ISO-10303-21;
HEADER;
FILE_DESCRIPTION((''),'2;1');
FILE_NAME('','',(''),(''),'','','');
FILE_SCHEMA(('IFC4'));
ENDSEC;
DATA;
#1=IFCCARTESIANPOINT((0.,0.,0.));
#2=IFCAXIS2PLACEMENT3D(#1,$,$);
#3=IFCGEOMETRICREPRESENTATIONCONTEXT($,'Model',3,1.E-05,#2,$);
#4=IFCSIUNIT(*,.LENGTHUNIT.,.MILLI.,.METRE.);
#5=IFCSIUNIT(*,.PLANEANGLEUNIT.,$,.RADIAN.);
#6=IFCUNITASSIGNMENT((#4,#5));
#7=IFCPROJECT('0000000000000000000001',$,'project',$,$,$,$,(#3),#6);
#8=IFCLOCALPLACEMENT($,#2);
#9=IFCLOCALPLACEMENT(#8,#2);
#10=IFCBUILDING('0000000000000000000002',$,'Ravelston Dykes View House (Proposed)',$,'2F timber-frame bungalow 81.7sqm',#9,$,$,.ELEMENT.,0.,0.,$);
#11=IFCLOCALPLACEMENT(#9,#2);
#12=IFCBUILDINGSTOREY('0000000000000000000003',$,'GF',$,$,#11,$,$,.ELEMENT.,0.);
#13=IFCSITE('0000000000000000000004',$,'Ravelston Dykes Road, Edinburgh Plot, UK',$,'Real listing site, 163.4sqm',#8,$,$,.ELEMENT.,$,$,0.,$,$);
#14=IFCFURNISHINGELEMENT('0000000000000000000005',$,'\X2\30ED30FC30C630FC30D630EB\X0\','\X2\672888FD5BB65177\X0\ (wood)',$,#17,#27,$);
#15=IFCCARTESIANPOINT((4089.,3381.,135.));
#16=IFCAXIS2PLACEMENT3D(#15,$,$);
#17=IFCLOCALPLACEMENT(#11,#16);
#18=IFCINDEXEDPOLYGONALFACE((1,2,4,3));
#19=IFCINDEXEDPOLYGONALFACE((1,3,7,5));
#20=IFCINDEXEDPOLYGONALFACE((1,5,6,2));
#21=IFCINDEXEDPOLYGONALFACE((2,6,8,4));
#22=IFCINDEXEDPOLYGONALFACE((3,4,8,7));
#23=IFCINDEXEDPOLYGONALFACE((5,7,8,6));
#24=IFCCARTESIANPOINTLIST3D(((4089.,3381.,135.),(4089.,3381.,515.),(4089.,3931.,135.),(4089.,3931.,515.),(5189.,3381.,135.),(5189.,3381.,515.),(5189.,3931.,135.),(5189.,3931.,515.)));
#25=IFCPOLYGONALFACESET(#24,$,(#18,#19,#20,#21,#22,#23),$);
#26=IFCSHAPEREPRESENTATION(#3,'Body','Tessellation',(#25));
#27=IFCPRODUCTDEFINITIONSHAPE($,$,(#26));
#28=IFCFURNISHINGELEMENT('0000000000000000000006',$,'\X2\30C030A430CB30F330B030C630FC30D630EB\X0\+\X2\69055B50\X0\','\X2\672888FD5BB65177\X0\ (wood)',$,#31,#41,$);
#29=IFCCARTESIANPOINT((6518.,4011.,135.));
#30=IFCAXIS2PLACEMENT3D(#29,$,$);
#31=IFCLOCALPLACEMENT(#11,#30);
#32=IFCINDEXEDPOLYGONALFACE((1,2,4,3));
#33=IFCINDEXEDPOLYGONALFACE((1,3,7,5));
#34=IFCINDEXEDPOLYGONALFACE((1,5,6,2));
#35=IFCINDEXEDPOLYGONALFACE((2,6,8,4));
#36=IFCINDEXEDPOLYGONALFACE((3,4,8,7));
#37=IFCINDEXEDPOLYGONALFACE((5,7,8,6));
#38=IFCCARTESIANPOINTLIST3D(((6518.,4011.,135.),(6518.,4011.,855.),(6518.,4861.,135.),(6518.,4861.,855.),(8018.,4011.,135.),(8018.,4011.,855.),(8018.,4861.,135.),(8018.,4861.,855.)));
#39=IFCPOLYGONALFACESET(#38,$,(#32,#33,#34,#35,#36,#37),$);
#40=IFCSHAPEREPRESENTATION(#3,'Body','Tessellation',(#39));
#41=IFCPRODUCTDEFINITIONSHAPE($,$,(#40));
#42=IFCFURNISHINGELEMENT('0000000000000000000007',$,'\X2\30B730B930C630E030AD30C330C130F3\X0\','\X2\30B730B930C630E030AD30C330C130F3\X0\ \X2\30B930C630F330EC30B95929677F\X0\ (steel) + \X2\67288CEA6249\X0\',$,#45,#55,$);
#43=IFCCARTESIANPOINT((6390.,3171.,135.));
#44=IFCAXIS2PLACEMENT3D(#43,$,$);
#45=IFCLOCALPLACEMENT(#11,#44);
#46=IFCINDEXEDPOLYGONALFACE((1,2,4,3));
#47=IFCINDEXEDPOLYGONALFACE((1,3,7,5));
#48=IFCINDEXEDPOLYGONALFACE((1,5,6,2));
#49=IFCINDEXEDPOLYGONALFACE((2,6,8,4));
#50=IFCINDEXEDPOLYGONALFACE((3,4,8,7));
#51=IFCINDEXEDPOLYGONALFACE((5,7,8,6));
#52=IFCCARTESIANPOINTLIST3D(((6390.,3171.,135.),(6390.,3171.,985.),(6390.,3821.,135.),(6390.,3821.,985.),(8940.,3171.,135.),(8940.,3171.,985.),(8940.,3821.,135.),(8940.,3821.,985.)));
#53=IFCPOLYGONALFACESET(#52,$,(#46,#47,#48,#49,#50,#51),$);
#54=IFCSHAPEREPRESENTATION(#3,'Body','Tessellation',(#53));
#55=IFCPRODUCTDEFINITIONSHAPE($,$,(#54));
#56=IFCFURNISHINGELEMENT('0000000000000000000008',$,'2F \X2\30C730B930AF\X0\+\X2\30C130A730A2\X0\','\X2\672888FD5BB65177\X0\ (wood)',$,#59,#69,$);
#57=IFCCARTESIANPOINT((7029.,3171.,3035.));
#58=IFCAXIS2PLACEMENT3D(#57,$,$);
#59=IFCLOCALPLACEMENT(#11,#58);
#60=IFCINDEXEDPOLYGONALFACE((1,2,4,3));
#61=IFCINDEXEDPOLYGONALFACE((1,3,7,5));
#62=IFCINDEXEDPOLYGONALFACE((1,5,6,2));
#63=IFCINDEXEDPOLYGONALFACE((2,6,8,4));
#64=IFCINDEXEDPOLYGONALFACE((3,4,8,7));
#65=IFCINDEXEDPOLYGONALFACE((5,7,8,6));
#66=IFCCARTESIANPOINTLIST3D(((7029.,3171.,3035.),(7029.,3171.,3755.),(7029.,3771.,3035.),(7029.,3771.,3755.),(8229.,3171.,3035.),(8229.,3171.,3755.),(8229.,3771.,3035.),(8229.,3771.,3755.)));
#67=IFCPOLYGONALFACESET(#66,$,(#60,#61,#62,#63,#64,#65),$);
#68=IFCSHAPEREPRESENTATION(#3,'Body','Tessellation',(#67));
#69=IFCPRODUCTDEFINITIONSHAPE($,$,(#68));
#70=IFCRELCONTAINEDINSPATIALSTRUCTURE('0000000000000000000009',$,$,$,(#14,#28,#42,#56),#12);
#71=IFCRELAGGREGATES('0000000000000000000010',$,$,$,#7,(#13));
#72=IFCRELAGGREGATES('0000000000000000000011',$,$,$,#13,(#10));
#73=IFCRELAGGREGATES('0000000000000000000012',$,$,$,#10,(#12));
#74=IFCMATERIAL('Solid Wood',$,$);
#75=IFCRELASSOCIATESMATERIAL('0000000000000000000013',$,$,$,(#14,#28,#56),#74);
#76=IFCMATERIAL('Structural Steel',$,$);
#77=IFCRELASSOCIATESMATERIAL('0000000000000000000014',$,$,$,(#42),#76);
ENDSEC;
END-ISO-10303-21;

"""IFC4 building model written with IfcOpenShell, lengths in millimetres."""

from ifc_helpers import new_model, si_unit, frame, frame_2d, origin, place, context, project, spatial, rectangle, extrude, material, element, save


model = new_model("IFC4")

# Units and contexts
model_context = context("Model", 3, precision=1e-05, world=origin())
ifc_project = project(units=[si_unit("LENGTHUNIT", "METRE", prefix="MILLI"), si_unit("PLANEANGLEUNIT", "RADIAN")], contexts=[model_context])

# Site, building, storey
site_placement = place(None, origin())
site = spatial("IfcSite", under=ifc_project, at=site_placement, Name="Ravelston Dykes Road, Edinburgh Plot, UK", ObjectType="Real listing site, 163.4sqm", CompositionType="ELEMENT", RefElevation=0.0)
building_placement = place(site_placement, origin())
building = spatial("IfcBuilding", under=site, at=building_placement, Name="Ravelston Dykes View House (Proposed)", ObjectType="2F timber-frame bungalow 81.7sqm", CompositionType="ELEMENT", ElevationOfRefHeight=0.0, ElevationOfTerrain=0.0)
storey_placement = place(building_placement, origin())
storey = spatial("IfcBuildingStorey", under=building, at=storey_placement, Name="GF", CompositionType="ELEMENT", Elevation=0.0)

# Shared definitions
ifc_material_1 = material(Name="Solid Wood")

# Shared definitions
ifc_material_2 = material(Name="Structural Steel")

# Furnishing elements
furnishing_1_placement = place(storey_placement, frame((4089.0, 3381.0, 135.0)))
element("IfcFurnishingElement", 1, at=furnishing_1_placement, inside=storey, material=ifc_material_1, Name="ローテーブル", Description="木製家具 (wood)", context=model_context, shape_type="SweptSolid", body=[
    extrude(rectangle(XDim=1100.0, YDim=550.0, at=frame_2d((550.0, 275.0))), frame((4089.0, 3381.0, 135.0)), (0.0, 0.0, 1.0), 380.0),
])
furnishing_2_placement = place(storey_placement, frame((6518.0, 4011.0, 135.0)))
element("IfcFurnishingElement", 2, at=furnishing_2_placement, inside=storey, material=ifc_material_1, Name="ダイニングテーブル+椅子", Description="木製家具 (wood)", context=model_context, shape_type="SweptSolid", body=[
    extrude(rectangle(XDim=1500.0, YDim=850.0, at=frame_2d((750.0, 425.0))), frame((6518.0, 4011.0, 135.0)), (0.0, 0.0, 1.0), 720.0),
])
furnishing_3_placement = place(storey_placement, frame((6390.0, 3171.0, 135.0)))
element("IfcFurnishingElement", 3, at=furnishing_3_placement, inside=storey, material=ifc_material_2, Name="システムキッチン", Description="システムキッチン ステンレス天板 (steel) + 木質扉", context=model_context, shape_type="SweptSolid", body=[
    extrude(rectangle(XDim=2550.0, YDim=650.0, at=frame_2d((1275.0, 325.0))), frame((6390.0, 3171.0, 135.0)), (0.0, 0.0, 1.0), 850.0),
])
furnishing_4_placement = place(storey_placement, frame((7029.0, 3171.0, 3035.0)))
element("IfcFurnishingElement", 4, at=furnishing_4_placement, inside=storey, material=ifc_material_1, Name="2F デスク+チェア", Description="木製家具 (wood)", context=model_context, shape_type="SweptSolid", body=[
    extrude(rectangle(XDim=1200.0, YDim=600.0, at=frame_2d((600.0, 300.0))), frame((7029.0, 3171.0, 3035.0)), (0.0, 0.0, 1.0), 720.0),
])

save(model, "model.ifc")
